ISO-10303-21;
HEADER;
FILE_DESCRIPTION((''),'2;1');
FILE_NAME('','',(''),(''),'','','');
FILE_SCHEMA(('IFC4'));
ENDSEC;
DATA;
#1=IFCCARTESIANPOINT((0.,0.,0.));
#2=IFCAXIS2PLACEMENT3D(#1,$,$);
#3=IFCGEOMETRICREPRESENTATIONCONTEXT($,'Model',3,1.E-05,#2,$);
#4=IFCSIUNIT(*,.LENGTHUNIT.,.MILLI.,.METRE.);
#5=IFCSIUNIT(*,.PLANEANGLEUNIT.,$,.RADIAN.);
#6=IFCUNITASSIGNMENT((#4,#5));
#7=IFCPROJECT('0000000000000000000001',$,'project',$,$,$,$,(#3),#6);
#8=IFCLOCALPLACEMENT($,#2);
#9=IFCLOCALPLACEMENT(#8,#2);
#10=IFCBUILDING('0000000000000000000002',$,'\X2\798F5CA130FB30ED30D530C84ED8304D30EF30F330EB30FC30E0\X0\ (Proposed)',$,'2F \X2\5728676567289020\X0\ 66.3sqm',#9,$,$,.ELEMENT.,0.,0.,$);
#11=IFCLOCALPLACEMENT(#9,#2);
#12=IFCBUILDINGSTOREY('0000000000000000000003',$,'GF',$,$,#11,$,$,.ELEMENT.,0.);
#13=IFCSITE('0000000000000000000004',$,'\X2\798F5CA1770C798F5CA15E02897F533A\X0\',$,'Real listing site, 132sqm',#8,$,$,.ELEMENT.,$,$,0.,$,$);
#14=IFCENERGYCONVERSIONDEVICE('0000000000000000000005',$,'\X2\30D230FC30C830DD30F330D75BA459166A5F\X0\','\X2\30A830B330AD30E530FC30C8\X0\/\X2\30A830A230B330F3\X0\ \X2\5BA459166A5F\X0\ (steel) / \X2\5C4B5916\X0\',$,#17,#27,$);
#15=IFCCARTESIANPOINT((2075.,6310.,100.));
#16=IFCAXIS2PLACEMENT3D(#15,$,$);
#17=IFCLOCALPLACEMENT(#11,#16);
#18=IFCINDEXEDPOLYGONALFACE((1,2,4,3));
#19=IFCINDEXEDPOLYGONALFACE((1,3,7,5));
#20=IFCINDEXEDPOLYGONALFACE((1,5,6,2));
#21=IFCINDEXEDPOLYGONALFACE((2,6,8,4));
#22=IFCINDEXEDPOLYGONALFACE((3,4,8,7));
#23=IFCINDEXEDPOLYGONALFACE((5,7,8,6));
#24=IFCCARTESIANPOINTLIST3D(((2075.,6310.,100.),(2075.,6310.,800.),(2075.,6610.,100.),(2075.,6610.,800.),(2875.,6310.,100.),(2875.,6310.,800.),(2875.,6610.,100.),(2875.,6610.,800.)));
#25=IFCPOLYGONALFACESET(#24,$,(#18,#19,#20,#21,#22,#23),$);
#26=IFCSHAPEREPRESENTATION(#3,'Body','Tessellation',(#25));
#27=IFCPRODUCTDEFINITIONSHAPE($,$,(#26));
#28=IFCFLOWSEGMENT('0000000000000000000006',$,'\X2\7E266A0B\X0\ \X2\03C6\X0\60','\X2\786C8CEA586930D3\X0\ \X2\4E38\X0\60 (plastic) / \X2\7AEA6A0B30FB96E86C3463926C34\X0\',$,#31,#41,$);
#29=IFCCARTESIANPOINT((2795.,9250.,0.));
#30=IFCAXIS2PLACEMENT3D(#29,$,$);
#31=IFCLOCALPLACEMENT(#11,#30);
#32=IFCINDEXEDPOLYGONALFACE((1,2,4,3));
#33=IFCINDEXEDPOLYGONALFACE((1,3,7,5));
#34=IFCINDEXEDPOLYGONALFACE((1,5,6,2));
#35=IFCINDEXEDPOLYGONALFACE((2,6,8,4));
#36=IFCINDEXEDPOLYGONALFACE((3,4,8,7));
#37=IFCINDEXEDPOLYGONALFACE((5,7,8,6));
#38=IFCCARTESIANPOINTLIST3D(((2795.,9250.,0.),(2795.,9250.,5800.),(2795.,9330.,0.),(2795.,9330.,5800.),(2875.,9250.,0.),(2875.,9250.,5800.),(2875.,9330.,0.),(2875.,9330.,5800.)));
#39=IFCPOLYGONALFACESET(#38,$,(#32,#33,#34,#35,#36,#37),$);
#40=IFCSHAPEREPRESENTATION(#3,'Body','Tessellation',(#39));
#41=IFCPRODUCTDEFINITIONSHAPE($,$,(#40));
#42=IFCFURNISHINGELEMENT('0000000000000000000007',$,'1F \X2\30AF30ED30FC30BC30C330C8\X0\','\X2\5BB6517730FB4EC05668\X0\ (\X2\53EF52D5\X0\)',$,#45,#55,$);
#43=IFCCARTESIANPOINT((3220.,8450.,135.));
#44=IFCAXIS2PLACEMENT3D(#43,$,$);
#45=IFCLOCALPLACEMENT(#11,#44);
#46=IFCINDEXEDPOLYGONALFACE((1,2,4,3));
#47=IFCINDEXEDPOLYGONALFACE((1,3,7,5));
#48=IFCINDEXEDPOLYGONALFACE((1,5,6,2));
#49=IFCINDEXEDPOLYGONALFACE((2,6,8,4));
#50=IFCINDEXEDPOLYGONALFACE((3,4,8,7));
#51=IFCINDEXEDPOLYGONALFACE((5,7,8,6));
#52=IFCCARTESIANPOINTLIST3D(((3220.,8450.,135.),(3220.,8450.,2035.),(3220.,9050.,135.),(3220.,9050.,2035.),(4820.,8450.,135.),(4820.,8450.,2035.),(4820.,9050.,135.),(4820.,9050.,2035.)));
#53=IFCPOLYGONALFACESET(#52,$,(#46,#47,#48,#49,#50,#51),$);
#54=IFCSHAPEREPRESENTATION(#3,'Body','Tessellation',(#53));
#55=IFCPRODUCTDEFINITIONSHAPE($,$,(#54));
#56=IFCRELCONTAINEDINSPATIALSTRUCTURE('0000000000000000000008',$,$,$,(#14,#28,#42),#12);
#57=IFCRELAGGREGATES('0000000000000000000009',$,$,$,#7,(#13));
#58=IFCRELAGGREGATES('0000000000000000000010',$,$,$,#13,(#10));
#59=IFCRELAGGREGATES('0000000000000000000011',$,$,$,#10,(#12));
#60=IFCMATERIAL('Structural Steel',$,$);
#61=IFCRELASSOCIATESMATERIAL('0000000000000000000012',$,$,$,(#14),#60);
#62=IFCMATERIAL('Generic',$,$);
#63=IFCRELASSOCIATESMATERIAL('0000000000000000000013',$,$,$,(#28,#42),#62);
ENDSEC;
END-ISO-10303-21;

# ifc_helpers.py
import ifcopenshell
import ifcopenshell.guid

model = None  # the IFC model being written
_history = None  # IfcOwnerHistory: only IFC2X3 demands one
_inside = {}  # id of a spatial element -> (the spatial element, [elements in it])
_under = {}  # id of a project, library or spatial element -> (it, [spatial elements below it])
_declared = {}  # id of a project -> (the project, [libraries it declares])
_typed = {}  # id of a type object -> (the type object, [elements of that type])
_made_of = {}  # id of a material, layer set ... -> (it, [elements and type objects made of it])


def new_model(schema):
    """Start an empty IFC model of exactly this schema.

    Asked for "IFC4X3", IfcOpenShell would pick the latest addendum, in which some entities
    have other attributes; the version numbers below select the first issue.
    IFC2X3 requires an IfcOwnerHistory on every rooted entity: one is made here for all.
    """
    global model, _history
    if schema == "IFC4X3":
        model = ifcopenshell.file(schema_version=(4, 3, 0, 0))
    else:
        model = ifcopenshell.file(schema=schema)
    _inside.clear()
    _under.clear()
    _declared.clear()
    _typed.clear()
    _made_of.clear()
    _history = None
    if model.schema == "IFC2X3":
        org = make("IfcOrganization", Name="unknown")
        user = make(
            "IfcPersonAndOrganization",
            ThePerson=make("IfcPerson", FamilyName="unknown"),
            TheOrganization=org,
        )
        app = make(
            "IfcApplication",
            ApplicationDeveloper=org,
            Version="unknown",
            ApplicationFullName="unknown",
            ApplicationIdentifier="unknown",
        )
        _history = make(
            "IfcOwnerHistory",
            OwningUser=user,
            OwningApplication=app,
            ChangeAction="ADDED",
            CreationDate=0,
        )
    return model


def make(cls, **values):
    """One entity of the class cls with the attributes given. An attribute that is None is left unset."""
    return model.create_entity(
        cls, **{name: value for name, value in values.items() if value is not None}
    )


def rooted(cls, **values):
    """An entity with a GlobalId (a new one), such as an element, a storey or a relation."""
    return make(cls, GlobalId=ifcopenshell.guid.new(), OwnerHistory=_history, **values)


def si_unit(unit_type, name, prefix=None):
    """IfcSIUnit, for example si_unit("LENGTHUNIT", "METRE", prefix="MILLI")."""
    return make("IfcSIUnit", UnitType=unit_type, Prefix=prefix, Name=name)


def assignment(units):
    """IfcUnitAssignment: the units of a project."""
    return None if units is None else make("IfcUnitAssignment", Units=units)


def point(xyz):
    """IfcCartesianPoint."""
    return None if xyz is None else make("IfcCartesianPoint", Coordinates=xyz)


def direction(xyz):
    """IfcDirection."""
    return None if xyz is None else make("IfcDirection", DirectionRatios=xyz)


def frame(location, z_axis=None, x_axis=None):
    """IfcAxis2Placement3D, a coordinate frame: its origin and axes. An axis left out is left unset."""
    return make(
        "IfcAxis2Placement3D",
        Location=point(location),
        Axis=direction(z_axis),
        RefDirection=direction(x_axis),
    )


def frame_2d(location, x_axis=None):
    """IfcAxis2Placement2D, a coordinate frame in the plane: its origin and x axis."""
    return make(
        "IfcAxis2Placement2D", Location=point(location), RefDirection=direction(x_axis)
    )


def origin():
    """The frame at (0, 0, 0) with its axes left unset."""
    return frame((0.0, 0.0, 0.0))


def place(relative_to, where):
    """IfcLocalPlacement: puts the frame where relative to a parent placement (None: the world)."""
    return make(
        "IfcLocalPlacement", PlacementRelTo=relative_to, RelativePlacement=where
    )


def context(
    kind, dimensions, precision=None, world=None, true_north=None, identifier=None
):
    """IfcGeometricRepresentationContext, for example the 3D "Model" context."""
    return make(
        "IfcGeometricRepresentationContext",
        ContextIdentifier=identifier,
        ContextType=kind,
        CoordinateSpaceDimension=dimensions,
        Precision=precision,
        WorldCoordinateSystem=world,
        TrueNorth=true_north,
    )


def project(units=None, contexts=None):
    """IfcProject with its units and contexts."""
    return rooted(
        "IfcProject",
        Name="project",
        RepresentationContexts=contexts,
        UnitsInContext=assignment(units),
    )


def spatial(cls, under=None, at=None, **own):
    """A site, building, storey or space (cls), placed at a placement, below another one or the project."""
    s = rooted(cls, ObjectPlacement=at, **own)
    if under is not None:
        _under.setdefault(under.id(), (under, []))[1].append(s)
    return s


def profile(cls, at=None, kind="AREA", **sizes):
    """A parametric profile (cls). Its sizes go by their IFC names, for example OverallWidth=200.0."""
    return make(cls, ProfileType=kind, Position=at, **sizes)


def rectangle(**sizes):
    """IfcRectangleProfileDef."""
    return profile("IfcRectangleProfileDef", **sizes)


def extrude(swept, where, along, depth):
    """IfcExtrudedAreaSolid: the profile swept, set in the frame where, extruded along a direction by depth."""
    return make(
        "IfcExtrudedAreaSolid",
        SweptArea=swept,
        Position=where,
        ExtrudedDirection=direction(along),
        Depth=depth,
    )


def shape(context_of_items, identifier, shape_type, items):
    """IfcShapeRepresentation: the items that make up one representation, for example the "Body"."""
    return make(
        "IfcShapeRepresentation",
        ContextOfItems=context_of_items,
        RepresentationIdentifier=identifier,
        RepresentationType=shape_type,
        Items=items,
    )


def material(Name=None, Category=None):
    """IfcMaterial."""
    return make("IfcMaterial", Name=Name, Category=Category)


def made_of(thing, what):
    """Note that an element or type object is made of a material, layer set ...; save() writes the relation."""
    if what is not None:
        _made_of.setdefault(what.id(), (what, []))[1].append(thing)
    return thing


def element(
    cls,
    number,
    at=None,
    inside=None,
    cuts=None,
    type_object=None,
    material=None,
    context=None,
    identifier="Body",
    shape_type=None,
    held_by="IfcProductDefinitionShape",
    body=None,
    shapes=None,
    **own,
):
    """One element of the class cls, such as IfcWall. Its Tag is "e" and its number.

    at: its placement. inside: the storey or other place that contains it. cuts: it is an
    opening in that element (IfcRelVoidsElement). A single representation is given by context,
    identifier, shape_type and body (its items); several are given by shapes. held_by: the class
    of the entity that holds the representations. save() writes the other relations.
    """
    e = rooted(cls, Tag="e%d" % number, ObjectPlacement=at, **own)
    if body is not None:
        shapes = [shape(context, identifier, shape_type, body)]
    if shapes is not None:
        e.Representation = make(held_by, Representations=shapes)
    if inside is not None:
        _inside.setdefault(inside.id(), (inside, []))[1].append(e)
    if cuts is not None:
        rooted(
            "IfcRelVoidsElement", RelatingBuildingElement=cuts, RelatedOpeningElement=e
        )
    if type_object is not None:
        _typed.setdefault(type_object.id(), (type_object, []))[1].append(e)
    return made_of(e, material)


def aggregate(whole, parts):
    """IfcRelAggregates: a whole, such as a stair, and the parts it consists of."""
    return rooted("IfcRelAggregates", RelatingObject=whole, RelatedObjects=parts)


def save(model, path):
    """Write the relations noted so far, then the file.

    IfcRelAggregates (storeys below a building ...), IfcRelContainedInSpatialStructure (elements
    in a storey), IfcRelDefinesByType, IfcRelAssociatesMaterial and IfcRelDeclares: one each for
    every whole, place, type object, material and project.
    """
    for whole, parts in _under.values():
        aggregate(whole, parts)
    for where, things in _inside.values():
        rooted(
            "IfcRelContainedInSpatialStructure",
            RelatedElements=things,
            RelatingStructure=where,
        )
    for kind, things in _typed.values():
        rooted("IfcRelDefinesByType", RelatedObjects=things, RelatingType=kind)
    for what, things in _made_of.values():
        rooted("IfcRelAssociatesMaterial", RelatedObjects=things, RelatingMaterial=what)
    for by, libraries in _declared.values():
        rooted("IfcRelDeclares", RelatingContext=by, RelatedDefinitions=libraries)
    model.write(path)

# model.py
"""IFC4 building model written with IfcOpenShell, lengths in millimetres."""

from ifc_helpers import new_model, si_unit, frame, frame_2d, origin, place, context, project, spatial, rectangle, extrude, material, element, save


model = new_model("IFC4")

# Units and contexts
model_context = context("Model", 3, precision=1e-05, world=origin())
ifc_project = project(units=[si_unit("LENGTHUNIT", "METRE", prefix="MILLI"), si_unit("PLANEANGLEUNIT", "RADIAN")], contexts=[model_context])

# Site, building, storey
site_placement = place(None, origin())
site = spatial("IfcSite", under=ifc_project, at=site_placement, Name="福岡県福岡市西区", ObjectType="Real listing site, 132sqm", CompositionType="ELEMENT", RefElevation=0.0)
building_placement = place(site_placement, origin())
building = spatial("IfcBuilding", under=site, at=building_placement, Name="福岡・ロフト付きワンルーム (Proposed)", ObjectType="2F 在来木造 66.3sqm", CompositionType="ELEMENT", ElevationOfRefHeight=0.0, ElevationOfTerrain=0.0)
storey_placement = place(building_placement, origin())
storey = spatial("IfcBuildingStorey", under=building, at=storey_placement, Name="GF", CompositionType="ELEMENT", Elevation=0.0)

# Shared definitions
ifc_material_1 = material(Name="Generic")

# Energy conversion device
ifc_material_2 = material(Name="Structural Steel")
energy_conversion_device_placement = place(storey_placement, frame((2075.0, 6310.0, 100.0)))
element("IfcEnergyConversionDevice", 1, at=energy_conversion_device_placement, inside=storey, material=ifc_material_2, Name="ヒートポンプ室外機", Description="エコキュート/エアコン 室外機 (steel) / 屋外", context=model_context, shape_type="SweptSolid", body=[
    extrude(rectangle(XDim=800.0, YDim=300.0, at=frame_2d((400.0, 150.0))), frame((2075.0, 6310.0, 100.0)), (0.0, 0.0, 1.0), 700.0),
])

# Flow segment
flow_segment_placement = place(storey_placement, frame((2795.0, 9250.0, 0.0)))
element("IfcFlowSegment", 2, at=flow_segment_placement, inside=storey, material=ifc_material_1, Name="縦樋 φ60", Description="硬質塩ビ 丸60 (plastic) / 竪樋・雨水排水", context=model_context, shape_type="SweptSolid", body=[
    extrude(rectangle(XDim=80.0, YDim=80.0, at=frame_2d((40.0, 40.0))), frame((2795.0, 9250.0, 0.0)), (0.0, 0.0, 1.0), 5800.0),
])

# Furnishing element
furnishing_placement = place(storey_placement, frame((3220.0, 8450.0, 135.0)))
element("IfcFurnishingElement", 3, at=furnishing_placement, inside=storey, material=ifc_material_1, Name="1F クローゼット", Description="家具・什器 (可動)", context=model_context, shape_type="SweptSolid", body=[
    extrude(rectangle(XDim=1600.0, YDim=600.0, at=frame_2d((800.0, 300.0))), frame((3220.0, 8450.0, 135.0)), (0.0, 0.0, 1.0), 1900.0),
])

save(model, "model.ifc")
